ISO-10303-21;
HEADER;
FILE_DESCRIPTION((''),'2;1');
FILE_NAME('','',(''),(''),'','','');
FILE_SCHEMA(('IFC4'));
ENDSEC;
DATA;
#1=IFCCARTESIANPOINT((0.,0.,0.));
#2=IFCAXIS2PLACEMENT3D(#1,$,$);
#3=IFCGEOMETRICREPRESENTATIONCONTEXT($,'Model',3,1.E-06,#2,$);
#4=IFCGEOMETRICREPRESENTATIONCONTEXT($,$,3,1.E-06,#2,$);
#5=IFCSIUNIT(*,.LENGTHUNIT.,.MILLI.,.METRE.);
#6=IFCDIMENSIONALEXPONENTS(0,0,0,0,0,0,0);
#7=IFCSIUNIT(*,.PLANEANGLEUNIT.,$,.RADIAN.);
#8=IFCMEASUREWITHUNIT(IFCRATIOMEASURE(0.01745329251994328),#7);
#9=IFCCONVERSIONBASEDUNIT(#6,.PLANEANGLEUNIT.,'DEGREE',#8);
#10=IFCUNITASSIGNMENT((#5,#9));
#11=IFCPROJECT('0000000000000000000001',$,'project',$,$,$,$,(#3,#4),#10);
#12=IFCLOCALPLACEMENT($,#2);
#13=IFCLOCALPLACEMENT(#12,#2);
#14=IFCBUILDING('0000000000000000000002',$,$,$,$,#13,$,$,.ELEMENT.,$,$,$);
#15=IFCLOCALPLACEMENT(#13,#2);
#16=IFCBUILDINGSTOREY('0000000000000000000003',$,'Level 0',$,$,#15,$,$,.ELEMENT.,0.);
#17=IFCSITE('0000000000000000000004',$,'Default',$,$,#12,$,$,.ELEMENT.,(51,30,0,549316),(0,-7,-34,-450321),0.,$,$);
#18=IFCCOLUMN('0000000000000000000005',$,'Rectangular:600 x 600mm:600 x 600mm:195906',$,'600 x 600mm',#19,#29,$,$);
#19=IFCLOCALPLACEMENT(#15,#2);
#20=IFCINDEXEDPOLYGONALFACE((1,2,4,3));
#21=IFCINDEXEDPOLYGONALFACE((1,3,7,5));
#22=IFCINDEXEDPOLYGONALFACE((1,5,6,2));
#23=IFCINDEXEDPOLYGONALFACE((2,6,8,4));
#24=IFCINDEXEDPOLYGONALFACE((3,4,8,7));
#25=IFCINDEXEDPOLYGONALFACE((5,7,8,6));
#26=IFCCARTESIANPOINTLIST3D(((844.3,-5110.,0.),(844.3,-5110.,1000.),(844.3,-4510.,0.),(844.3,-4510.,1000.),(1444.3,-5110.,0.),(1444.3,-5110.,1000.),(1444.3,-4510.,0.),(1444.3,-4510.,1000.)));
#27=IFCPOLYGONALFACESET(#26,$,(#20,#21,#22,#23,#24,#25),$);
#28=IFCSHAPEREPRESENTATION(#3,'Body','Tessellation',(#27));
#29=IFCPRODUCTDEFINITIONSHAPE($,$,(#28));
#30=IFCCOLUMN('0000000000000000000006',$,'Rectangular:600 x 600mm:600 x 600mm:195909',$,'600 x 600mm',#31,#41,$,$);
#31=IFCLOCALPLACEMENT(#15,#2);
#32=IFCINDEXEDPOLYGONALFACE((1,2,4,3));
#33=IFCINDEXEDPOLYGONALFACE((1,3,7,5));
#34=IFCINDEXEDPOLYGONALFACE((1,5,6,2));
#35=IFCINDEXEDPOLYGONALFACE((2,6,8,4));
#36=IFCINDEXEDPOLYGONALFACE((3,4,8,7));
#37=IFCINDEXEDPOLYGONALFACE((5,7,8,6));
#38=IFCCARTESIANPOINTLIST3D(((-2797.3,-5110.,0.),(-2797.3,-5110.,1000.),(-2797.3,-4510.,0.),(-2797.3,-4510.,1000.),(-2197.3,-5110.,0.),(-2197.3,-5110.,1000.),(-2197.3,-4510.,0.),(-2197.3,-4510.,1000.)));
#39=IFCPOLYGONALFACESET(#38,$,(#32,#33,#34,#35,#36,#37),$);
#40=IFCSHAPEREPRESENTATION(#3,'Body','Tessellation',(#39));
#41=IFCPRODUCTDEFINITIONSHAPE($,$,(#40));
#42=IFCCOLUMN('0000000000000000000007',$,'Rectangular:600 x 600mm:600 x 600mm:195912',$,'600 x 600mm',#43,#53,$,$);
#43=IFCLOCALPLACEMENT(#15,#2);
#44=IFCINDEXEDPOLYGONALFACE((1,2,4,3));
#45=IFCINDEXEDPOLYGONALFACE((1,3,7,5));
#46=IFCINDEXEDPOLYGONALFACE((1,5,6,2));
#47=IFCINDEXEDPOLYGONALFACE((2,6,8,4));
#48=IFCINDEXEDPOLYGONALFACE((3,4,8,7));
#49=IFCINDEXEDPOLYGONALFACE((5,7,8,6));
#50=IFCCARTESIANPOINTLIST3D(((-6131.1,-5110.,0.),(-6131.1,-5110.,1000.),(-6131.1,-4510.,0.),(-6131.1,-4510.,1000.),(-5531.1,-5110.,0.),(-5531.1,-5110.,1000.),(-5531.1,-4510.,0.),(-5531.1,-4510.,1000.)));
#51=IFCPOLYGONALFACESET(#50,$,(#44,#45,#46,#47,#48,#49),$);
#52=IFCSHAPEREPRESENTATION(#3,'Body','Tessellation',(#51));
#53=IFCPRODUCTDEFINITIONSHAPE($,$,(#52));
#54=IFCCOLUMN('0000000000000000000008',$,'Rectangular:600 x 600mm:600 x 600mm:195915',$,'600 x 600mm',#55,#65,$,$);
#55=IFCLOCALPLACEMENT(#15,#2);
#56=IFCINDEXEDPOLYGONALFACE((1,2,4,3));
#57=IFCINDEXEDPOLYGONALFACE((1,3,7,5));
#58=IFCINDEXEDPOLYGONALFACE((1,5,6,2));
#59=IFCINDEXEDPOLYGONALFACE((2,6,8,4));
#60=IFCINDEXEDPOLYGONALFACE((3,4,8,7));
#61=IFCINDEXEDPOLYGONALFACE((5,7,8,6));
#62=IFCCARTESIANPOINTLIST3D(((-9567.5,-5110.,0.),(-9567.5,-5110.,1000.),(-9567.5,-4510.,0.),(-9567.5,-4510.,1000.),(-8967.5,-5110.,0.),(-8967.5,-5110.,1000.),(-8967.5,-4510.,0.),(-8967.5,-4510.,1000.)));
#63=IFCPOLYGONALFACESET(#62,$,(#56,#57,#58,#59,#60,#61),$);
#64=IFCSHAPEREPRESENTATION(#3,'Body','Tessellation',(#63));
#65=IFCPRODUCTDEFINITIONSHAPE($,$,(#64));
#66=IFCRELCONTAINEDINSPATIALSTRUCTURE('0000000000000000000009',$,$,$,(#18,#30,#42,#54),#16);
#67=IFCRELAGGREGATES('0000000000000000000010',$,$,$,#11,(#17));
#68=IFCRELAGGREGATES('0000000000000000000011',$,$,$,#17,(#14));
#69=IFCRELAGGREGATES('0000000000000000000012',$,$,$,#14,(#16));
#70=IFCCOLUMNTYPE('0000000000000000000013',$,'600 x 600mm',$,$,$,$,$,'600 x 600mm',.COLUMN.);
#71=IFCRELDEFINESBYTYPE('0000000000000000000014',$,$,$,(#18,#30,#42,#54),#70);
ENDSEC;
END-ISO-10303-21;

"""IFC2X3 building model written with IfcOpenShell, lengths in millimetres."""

from ifc_helpers import new_model, entity, si_unit, converted_unit, frame, frame_2d, origin, place, context, project, spatial, rectangle, extrude, source, transform, mapped, type_object, type_shapes, element, save


model = new_model("IFC2X3")

# Units and contexts
model_context = context("Model", 3, precision=1e-06, world=origin())
context_of_model = context(None, 3, precision=1e-06, world=origin())
ifc_project = project(units=[si_unit("LENGTHUNIT", "METRE", prefix="MILLI"), converted_unit("PLANEANGLEUNIT", "DEGREE", entity("IfcRatioMeasure", 0.01745329251994328), si_unit("PLANEANGLEUNIT", "RADIAN"), dimensions=[0, 0, 0, 0, 0, 0, 0])], contexts=[model_context, context_of_model])

# Site, building, storey
site_placement = place(None, origin())
site = spatial("IfcSite", under=ifc_project, at=site_placement, Name="Default", CompositionType="ELEMENT", RefLatitude=(51, 30, 0, 549316), RefLongitude=(0, -7, -34, -450321), RefElevation=0.0)
building_placement = place(site_placement, origin())
building = spatial("IfcBuilding", under=site, at=building_placement, CompositionType="ELEMENT")
storey_placement = place(building_placement, origin())
storey = spatial("IfcBuildingStorey", under=building, at=storey_placement, Name="Level 0", CompositionType="ELEMENT", Elevation=0.0)

# Columns
column_type = type_object("IfcColumnType", Name="600 x 600mm", ElementType="600 x 600mm", PredefinedType="COLUMN")
shared_shape = source(origin(), model_context, "Body", "SweptSolid", [
    extrude(rectangle(XDim=600.0, YDim=600.0, at=frame_2d((0.0, 0.0), x_axis=(0.0, -1.0))), origin(), (0.0, 0.0, 1.0), 1000.0),
])
type_shapes(column_type, [shared_shape])
for number, where, name in (
    (1, (1144.3, -4810.0, 0.0), "Rectangular:600 x 600mm:600 x 600mm:195906"),
    (2, (-2497.3, -4810.0, 0.0), "Rectangular:600 x 600mm:600 x 600mm:195909"),
    (3, (-5831.1, -4810.0, 0.0), "Rectangular:600 x 600mm:600 x 600mm:195912"),
    (4, (-9267.5, -4810.0, 0.0), "Rectangular:600 x 600mm:600 x 600mm:195915"),
):
    element("IfcColumn", number, at=place(storey_placement, frame(where)), inside=storey, type_object=column_type, Name=name, ObjectType="600 x 600mm", context=model_context, shape_type="MappedRepresentation", body=[
        mapped(shared_shape, transform((0.0, 0.0, 0.0), scale=1.0)),
    ])

save(model, "model.ifc")
